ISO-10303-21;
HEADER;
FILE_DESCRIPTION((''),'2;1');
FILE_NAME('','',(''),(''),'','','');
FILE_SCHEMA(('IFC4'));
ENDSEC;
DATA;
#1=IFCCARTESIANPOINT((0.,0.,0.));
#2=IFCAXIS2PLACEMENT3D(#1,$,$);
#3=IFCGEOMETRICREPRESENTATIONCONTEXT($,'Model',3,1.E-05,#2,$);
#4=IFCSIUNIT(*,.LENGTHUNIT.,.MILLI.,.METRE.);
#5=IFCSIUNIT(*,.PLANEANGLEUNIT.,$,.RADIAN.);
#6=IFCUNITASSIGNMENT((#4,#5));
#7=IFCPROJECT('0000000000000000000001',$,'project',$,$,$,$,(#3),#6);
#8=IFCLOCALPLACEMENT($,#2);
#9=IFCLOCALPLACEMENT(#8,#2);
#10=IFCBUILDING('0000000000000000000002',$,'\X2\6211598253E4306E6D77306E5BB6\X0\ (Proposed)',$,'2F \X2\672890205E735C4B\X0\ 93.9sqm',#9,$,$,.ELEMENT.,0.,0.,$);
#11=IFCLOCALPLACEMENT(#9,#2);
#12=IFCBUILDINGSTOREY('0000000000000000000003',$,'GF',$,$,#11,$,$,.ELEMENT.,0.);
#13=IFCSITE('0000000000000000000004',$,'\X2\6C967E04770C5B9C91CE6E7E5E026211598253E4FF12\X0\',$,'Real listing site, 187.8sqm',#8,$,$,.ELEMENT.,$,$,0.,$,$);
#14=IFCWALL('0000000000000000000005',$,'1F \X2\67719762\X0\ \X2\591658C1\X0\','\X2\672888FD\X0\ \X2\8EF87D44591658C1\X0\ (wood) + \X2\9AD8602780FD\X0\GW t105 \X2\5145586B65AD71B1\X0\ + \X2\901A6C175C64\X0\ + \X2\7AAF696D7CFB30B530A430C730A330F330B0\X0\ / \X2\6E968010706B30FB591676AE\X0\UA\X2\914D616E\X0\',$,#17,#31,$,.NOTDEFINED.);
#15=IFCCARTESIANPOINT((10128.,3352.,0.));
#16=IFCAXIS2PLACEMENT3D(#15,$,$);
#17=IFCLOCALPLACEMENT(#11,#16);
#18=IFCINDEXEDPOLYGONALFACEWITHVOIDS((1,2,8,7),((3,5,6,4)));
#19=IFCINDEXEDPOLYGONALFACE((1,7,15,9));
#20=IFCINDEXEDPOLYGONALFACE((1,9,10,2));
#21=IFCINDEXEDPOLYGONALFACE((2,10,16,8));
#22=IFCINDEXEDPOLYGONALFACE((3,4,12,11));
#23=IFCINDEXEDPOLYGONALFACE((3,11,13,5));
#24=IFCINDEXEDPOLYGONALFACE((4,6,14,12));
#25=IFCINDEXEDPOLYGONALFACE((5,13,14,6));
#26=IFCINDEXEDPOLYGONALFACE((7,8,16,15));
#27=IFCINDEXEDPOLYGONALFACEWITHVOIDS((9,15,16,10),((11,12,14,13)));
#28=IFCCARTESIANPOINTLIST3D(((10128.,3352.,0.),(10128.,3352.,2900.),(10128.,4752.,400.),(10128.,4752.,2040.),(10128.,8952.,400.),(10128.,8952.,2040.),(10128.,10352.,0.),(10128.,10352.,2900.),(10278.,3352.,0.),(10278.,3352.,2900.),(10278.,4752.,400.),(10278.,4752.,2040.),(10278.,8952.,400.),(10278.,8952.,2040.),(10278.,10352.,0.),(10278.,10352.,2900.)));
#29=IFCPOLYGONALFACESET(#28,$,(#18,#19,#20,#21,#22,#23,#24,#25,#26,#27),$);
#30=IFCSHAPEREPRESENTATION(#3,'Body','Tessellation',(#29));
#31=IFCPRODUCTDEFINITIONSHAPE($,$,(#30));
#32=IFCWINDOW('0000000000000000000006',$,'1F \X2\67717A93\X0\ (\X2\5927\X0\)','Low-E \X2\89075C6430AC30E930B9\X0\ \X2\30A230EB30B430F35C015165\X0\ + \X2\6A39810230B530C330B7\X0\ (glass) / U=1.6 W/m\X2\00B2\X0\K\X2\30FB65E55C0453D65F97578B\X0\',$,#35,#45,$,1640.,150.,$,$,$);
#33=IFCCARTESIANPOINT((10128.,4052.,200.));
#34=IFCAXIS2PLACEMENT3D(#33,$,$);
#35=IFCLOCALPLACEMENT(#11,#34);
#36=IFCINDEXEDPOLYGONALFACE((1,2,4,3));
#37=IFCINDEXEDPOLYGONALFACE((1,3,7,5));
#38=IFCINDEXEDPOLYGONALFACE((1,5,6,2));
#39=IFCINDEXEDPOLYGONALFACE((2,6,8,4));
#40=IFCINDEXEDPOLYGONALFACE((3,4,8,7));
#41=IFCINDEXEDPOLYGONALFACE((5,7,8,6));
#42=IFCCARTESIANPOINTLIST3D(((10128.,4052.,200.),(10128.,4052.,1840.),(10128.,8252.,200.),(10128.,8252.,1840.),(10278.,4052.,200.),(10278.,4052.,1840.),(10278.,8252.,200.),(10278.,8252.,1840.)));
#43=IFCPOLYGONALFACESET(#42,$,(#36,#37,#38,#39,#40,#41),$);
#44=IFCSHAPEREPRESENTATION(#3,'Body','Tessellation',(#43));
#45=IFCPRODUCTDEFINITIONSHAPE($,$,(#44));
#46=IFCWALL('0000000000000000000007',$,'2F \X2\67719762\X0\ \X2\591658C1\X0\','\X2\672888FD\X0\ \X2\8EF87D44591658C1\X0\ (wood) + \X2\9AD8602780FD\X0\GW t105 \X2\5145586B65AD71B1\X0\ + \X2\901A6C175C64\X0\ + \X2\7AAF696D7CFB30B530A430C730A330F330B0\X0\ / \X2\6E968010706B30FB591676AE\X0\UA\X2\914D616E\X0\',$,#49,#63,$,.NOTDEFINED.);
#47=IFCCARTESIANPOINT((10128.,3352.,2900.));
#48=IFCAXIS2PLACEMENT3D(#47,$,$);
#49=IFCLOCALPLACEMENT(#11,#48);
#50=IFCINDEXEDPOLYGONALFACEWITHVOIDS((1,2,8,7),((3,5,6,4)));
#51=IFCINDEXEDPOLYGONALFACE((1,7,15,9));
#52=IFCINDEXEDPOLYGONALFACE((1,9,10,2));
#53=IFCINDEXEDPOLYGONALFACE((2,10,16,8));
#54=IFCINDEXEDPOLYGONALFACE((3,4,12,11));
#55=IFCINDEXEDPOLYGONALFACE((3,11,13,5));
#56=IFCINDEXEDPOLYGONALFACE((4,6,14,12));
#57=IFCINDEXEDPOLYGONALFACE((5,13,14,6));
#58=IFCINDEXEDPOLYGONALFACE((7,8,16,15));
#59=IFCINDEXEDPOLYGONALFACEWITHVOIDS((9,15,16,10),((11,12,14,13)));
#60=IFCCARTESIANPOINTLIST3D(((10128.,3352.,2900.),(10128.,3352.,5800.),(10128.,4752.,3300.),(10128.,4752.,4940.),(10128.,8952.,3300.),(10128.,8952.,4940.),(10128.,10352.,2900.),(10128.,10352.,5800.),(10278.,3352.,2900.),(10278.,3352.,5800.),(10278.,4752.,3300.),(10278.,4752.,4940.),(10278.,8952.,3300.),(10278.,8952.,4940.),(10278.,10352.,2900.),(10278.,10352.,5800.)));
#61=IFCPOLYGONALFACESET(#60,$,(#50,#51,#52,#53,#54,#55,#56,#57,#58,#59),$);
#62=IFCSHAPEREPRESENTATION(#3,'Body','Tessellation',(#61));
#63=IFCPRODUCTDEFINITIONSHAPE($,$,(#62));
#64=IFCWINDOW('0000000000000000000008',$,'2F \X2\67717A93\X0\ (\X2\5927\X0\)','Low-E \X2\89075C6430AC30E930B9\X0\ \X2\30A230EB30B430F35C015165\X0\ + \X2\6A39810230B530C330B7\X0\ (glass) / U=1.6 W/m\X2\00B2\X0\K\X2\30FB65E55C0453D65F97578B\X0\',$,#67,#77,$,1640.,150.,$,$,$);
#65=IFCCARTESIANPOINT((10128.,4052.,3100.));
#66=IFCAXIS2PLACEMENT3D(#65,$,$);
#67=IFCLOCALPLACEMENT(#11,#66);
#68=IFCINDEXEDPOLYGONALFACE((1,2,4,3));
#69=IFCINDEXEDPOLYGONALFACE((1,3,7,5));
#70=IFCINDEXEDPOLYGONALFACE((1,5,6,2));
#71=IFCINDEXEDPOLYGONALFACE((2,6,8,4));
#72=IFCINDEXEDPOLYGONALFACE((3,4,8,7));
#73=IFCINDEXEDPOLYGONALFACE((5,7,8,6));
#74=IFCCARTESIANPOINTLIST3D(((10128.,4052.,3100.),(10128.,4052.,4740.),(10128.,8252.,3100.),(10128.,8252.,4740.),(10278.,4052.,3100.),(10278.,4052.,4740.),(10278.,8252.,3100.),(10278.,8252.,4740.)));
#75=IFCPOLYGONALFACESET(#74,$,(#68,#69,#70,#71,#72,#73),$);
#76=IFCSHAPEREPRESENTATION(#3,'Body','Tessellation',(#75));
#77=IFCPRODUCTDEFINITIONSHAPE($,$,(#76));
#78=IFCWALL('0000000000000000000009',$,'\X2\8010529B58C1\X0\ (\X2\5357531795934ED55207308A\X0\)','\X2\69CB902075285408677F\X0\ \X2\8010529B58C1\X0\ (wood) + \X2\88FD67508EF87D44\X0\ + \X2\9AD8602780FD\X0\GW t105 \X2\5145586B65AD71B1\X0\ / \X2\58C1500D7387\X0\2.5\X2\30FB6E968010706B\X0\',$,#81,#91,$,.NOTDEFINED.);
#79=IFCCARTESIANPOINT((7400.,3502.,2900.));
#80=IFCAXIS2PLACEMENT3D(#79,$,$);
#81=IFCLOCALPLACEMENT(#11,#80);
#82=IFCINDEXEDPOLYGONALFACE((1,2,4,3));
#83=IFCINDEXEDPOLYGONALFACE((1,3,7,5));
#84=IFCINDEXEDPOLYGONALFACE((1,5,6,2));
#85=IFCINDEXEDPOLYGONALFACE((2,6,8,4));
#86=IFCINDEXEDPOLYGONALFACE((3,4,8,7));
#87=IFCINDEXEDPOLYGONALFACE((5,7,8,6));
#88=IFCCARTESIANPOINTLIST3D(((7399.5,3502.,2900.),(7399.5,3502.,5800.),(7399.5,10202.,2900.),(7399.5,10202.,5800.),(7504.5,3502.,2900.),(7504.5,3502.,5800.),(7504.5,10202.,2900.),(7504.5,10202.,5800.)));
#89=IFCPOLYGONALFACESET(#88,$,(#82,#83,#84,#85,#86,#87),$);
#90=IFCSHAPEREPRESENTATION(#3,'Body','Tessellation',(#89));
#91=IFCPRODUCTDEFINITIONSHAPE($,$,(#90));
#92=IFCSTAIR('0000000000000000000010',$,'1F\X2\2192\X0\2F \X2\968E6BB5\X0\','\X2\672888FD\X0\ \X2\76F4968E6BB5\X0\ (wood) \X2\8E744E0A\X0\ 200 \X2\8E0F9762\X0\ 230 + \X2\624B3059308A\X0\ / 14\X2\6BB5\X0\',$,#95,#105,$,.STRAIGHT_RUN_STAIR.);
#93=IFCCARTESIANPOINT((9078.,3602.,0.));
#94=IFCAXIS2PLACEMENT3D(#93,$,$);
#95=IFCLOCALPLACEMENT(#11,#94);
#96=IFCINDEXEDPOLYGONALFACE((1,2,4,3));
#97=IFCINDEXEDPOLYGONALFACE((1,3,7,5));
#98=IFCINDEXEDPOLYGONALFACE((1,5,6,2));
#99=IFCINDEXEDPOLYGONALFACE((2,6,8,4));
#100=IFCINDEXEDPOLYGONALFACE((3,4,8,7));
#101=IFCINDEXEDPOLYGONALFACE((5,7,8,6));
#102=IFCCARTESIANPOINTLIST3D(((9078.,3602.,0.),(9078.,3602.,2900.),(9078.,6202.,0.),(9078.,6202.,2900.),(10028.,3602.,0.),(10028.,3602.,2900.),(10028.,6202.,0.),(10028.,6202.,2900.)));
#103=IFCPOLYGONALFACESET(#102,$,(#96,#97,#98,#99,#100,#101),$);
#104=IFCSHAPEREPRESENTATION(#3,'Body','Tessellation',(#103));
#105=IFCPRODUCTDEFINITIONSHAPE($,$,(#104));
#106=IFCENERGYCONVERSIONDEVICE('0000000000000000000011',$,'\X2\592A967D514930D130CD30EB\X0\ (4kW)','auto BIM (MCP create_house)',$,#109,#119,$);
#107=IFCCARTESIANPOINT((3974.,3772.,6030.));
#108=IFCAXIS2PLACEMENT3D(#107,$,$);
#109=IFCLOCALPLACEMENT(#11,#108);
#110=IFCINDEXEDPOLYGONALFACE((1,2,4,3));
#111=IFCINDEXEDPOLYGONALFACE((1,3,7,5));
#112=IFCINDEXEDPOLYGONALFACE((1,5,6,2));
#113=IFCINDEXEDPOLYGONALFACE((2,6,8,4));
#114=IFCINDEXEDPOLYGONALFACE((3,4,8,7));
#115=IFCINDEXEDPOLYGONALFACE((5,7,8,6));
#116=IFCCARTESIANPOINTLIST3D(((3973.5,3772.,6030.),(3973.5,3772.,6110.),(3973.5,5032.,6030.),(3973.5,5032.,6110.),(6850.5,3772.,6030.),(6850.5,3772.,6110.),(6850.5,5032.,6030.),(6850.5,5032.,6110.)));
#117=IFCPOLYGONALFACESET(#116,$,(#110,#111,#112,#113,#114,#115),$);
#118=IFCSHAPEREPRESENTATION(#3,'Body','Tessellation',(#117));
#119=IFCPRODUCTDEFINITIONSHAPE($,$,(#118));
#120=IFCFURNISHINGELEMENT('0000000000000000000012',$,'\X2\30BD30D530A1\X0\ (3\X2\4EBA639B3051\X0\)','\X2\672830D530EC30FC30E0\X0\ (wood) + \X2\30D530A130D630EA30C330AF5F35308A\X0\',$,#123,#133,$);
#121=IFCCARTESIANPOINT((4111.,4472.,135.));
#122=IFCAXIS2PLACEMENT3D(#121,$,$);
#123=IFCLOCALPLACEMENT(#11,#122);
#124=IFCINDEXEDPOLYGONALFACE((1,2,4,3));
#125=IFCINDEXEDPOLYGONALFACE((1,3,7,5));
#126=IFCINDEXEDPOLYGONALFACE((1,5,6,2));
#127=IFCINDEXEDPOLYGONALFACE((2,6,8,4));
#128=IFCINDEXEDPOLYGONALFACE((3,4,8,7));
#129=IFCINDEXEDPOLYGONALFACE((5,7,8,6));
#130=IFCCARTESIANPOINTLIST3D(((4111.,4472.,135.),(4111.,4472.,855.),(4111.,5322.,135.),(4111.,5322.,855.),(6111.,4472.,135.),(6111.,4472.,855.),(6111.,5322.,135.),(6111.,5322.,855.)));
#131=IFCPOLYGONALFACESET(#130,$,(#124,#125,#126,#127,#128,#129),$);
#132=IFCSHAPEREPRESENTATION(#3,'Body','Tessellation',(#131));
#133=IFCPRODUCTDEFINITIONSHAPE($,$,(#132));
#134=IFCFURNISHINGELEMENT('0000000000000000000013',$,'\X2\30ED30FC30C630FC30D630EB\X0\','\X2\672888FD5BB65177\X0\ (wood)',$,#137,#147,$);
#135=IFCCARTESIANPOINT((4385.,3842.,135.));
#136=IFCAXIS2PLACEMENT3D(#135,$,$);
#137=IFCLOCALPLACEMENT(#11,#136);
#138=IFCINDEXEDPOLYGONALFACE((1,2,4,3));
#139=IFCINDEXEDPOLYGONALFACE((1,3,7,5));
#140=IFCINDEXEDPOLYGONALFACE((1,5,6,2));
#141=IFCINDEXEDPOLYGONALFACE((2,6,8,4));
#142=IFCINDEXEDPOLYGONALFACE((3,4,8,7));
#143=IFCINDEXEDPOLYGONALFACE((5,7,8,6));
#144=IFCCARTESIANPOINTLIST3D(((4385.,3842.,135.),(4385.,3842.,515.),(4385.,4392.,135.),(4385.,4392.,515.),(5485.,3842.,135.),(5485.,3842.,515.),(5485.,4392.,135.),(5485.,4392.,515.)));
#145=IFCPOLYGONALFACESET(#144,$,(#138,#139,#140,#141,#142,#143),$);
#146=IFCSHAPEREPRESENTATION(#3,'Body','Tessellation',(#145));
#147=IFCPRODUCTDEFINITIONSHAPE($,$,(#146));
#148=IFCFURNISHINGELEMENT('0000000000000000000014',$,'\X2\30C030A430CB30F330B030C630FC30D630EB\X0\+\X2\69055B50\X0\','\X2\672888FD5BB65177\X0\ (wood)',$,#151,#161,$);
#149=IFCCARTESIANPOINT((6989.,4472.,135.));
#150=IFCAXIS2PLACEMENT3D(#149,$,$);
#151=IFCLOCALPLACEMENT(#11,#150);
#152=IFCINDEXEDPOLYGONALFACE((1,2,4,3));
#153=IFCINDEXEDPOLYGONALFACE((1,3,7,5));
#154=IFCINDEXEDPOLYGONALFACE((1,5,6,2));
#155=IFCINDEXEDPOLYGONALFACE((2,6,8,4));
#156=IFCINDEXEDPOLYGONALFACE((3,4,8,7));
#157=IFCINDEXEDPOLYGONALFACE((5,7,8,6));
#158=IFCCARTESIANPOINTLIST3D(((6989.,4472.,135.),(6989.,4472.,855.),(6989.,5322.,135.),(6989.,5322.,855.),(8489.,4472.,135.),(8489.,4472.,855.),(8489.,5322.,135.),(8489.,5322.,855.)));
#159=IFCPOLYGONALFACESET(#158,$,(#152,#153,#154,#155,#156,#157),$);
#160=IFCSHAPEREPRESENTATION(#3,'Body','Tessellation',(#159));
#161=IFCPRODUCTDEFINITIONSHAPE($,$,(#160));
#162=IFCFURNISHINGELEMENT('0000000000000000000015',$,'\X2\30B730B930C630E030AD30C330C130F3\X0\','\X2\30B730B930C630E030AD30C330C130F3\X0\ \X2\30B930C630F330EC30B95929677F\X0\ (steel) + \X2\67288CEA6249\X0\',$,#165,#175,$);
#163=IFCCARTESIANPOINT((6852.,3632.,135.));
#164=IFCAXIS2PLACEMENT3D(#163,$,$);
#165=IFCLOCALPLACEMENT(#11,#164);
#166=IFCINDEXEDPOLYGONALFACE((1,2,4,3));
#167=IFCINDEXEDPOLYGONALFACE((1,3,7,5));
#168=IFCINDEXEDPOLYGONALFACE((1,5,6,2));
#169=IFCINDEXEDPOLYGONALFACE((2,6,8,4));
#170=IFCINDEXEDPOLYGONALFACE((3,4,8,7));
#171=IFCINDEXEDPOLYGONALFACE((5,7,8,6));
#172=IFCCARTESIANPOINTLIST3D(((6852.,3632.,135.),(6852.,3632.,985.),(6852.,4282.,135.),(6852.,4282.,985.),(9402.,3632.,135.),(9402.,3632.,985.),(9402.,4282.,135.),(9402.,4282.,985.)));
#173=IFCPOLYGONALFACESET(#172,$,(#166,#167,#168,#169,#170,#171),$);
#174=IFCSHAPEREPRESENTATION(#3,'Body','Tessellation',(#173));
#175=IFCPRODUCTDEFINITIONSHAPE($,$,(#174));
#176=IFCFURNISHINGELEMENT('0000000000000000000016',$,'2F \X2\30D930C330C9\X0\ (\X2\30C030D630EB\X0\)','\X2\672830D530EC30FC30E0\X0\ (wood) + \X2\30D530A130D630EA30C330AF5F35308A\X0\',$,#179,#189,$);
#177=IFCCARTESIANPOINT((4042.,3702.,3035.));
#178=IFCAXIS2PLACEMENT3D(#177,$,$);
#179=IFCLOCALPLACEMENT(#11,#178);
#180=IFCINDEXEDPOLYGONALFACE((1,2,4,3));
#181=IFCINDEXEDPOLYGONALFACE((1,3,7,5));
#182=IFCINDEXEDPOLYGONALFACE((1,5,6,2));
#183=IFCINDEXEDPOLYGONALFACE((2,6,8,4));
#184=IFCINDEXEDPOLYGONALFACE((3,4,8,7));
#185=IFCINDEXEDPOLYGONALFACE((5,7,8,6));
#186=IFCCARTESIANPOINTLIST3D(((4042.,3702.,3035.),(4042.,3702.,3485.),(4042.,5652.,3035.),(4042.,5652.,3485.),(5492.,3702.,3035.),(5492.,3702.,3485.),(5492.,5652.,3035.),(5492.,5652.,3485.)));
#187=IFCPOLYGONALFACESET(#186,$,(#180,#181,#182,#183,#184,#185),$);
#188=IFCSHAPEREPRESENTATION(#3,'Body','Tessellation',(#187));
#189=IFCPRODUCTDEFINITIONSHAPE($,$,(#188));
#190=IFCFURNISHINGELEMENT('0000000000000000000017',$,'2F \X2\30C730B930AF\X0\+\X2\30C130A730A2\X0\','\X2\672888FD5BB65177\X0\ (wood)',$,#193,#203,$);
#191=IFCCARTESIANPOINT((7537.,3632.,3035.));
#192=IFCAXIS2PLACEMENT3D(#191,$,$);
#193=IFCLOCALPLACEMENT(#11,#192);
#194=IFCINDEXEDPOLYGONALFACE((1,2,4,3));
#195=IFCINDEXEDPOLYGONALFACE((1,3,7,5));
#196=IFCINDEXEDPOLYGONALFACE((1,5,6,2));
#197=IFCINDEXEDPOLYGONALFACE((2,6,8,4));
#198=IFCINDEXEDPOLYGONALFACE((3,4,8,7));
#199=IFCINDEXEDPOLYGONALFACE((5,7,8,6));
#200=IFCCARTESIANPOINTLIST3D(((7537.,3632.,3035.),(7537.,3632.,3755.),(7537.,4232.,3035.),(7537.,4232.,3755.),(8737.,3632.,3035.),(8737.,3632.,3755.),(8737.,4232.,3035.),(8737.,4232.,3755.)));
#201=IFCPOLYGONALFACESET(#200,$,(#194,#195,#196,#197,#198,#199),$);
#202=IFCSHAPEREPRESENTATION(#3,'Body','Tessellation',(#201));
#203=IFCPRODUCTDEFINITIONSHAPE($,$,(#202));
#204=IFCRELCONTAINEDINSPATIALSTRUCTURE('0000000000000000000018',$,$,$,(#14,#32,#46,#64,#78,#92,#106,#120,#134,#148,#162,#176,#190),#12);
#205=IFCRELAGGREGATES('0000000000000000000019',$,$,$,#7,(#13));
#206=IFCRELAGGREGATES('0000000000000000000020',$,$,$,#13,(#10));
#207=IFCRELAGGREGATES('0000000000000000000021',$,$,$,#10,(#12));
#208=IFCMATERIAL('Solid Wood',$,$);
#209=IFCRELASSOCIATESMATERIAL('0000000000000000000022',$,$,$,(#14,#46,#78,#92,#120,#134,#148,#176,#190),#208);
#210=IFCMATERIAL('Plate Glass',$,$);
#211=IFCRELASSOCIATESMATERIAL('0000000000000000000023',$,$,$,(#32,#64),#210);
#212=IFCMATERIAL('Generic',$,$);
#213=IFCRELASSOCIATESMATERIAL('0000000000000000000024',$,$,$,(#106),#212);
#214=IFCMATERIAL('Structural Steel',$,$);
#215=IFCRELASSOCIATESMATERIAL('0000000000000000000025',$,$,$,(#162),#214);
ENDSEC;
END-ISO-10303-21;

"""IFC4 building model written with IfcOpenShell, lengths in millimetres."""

from ifc_helpers import new_model, si_unit, frame, frame_2d, origin, place, context, project, spatial, rectangle, extrude, material, element, fill, save


model = new_model("IFC4")

# Units and contexts
model_context = context("Model", 3, precision=1e-05, world=origin())
ifc_project = project(units=[si_unit("LENGTHUNIT", "METRE", prefix="MILLI"), si_unit("PLANEANGLEUNIT", "RADIAN")], contexts=[model_context])

# Site, building, storey
site_placement = place(None, origin())
site = spatial("IfcSite", under=ifc_project, at=site_placement, Name="沖縄県宜野湾市我如古２", ObjectType="Real listing site, 187.8sqm", CompositionType="ELEMENT", RefElevation=0.0)
building_placement = place(site_placement, origin())
building = spatial("IfcBuilding", under=site, at=building_placement, Name="我如古の海の家 (Proposed)", ObjectType="2F 木造平屋 93.9sqm", CompositionType="ELEMENT", ElevationOfRefHeight=0.0, ElevationOfTerrain=0.0)
storey_placement = place(building_placement, origin())
storey = spatial("IfcBuildingStorey", under=building, at=storey_placement, Name="GF", CompositionType="ELEMENT", Elevation=0.0)

# Wall, opening, window
ifc_material_1 = material(Name="Solid Wood")
wall_1_placement = place(storey_placement, frame((10128.0, 3352.0, 0.0)))
wall_1 = element("IfcWall", 1, at=wall_1_placement, inside=storey, material=ifc_material_1, Name="1F 東面 外壁", Description="木製 軸組外壁 (wood) + 高性能GW t105 充填断熱 + 通気層 + 窯業系サイディング / 準耐火・外皮UA配慮", PredefinedType="NOTDEFINED", context=model_context, shape_type="SweptSolid", body=[
    extrude(rectangle(XDim=150.0, YDim=7000.0, at=frame_2d((75.0, 3500.0))), frame((10128.0, 3352.0, 0.0)), (0.0, 0.0, 1.0), 2900.0),
])
opening_1_placement = place(storey_placement, frame((10128.0, 4052.0, 200.0)))
opening_1 = element("IfcOpeningElement", 2, at=opening_1_placement, cuts=wall_1, PredefinedType="NOTDEFINED", context=model_context, shape_type="SweptSolid", body=[
    extrude(rectangle(XDim=150.0, YDim=4200.0, at=frame_2d((75.0, 2100.0))), frame((10128.0, 4052.0, 200.0)), (0.0, 0.0, 1.0), 1640.0),
])
ifc_material_2 = material(Name="Plate Glass")
window_1_placement = place(storey_placement, frame((10128.0, 4052.0, 200.0)))
window_1 = element("IfcWindow", 3, at=window_1_placement, inside=storey, material=ifc_material_2, Name="1F 東窓 (大)", Description="Low-E 複層ガラス アルゴン封入 + 樹脂サッシ (glass) / U=1.6 W/m²K・日射取得型", OverallHeight=1640.0, OverallWidth=150.0, context=model_context, shape_type="SweptSolid", body=[
    extrude(rectangle(XDim=150.0, YDim=4200.0, at=frame_2d((75.0, 2100.0))), frame((10128.0, 4052.0, 200.0)), (0.0, 0.0, 1.0), 1640.0),
])
fill(opening_1, window_1)

# Wall, opening, window
wall_2_placement = place(storey_placement, frame((10128.0, 3352.0, 2900.0)))
wall_2 = element("IfcWall", 4, at=wall_2_placement, inside=storey, material=ifc_material_1, Name="2F 東面 外壁", Description="木製 軸組外壁 (wood) + 高性能GW t105 充填断熱 + 通気層 + 窯業系サイディング / 準耐火・外皮UA配慮", PredefinedType="NOTDEFINED", context=model_context, shape_type="SweptSolid", body=[
    extrude(rectangle(XDim=150.0, YDim=7000.0, at=frame_2d((75.0, 3500.0))), frame((10128.0, 3352.0, 2900.0)), (0.0, 0.0, 1.0), 2900.0),
])
opening_2_placement = place(storey_placement, frame((10128.0, 4052.0, 3100.0)))
opening_2 = element("IfcOpeningElement", 5, at=opening_2_placement, cuts=wall_2, PredefinedType="NOTDEFINED", context=model_context, shape_type="SweptSolid", body=[
    extrude(rectangle(XDim=150.0, YDim=4200.0, at=frame_2d((75.0, 2100.0))), frame((10128.0, 4052.0, 3100.0)), (0.0, 0.0, 1.0), 1640.0),
])
window_2_placement = place(storey_placement, frame((10128.0, 4052.0, 3100.0)))
window_2 = element("IfcWindow", 6, at=window_2_placement, inside=storey, material=ifc_material_2, Name="2F 東窓 (大)", Description="Low-E 複層ガラス アルゴン封入 + 樹脂サッシ (glass) / U=1.6 W/m²K・日射取得型", OverallHeight=1640.0, OverallWidth=150.0, context=model_context, shape_type="SweptSolid", body=[
    extrude(rectangle(XDim=150.0, YDim=4200.0, at=frame_2d((75.0, 2100.0))), frame((10128.0, 4052.0, 3100.0)), (0.0, 0.0, 1.0), 1640.0),
])
fill(opening_2, window_2)

# Wall
wall_3_placement = place(storey_placement, frame((7400.0, 3502.0, 2900.0)))
element("IfcWall", 7, at=wall_3_placement, inside=storey, material=ifc_material_1, Name="耐力壁 (南北間仕切り)", Description="構造用合板 耐力壁 (wood) + 製材軸組 + 高性能GW t105 充填断熱 / 壁倍率2.5・準耐火", PredefinedType="NOTDEFINED", context=model_context, shape_type="SweptSolid", body=[
    extrude(rectangle(XDim=105.0, YDim=6700.0, at=frame_2d((52.0, 3350.0))), frame((7400.0, 3502.0, 2900.0)), (0.0, 0.0, 1.0), 2900.0),
])

# Stair
stair_placement = place(storey_placement, frame((9078.0, 3602.0, 0.0)))
element("IfcStair", 8, at=stair_placement, inside=storey, material=ifc_material_1, Name="1F→2F 階段", Description="木製 直階段 (wood) 蹴上 200 踏面 230 + 手すり / 14段", PredefinedType="STRAIGHT_RUN_STAIR", context=model_context, shape_type="SweptSolid", body=[
    extrude(rectangle(XDim=950.0, YDim=2600.0, at=frame_2d((475.0, 1300.0))), frame((9078.0, 3602.0, 0.0)), (0.0, 0.0, 1.0), 2900.0),
])

# Energy conversion device
ifc_material_3 = material(Name="Generic")
energy_conversion_device_placement = place(storey_placement, frame((3974.0, 3772.0, 6030.0)))
element("IfcEnergyConversionDevice", 9, at=energy_conversion_device_placement, inside=storey, material=ifc_material_3, Name="太陽光パネル (4kW)", Description="auto BIM (MCP create_house)", context=model_context, shape_type="SweptSolid", body=[
    extrude(rectangle(XDim=2877.0, YDim=1260.0, at=frame_2d((1438.0, 630.0))), frame((3974.0, 3772.0, 6030.0)), (0.0, 0.0, 1.0), 80.0),
])

# Furnishing elements
furnishing_1_placement = place(storey_placement, frame((4111.0, 4472.0, 135.0)))
element("IfcFurnishingElement", 10, at=furnishing_1_placement, inside=storey, material=ifc_material_1, Name="ソファ (3人掛け)", Description="木フレーム (wood) + ファブリック張り", context=model_context, shape_type="SweptSolid", body=[
    extrude(rectangle(XDim=2000.0, YDim=850.0, at=frame_2d((1000.0, 425.0))), frame((4111.0, 4472.0, 135.0)), (0.0, 0.0, 1.0), 720.0),
])
furnishing_2_placement = place(storey_placement, frame((4385.0, 3842.0, 135.0)))
element("IfcFurnishingElement", 11, at=furnishing_2_placement, inside=storey, material=ifc_material_1, Name="ローテーブル", Description="木製家具 (wood)", context=model_context, shape_type="SweptSolid", body=[
    extrude(rectangle(XDim=1100.0, YDim=550.0, at=frame_2d((550.0, 275.0))), frame((4385.0, 3842.0, 135.0)), (0.0, 0.0, 1.0), 380.0),
])
furnishing_3_placement = place(storey_placement, frame((6989.0, 4472.0, 135.0)))
element("IfcFurnishingElement", 12, at=furnishing_3_placement, inside=storey, material=ifc_material_1, Name="ダイニングテーブル+椅子", Description="木製家具 (wood)", context=model_context, shape_type="SweptSolid", body=[
    extrude(rectangle(XDim=1500.0, YDim=850.0, at=frame_2d((750.0, 425.0))), frame((6989.0, 4472.0, 135.0)), (0.0, 0.0, 1.0), 720.0),
])
ifc_material_4 = material(Name="Structural Steel")
furnishing_4_placement = place(storey_placement, frame((6852.0, 3632.0, 135.0)))
element("IfcFurnishingElement", 13, at=furnishing_4_placement, inside=storey, material=ifc_material_4, Name="システムキッチン", Description="システムキッチン ステンレス天板 (steel) + 木質扉", context=model_context, shape_type="SweptSolid", body=[
    extrude(rectangle(XDim=2550.0, YDim=650.0, at=frame_2d((1275.0, 325.0))), frame((6852.0, 3632.0, 135.0)), (0.0, 0.0, 1.0), 850.0),
])
furnishing_5_placement = place(storey_placement, frame((4042.0, 3702.0, 3035.0)))
element("IfcFurnishingElement", 14, at=furnishing_5_placement, inside=storey, material=ifc_material_1, Name="2F ベッド (ダブル)", Description="木フレーム (wood) + ファブリック張り", context=model_context, shape_type="SweptSolid", body=[
    extrude(rectangle(XDim=1450.0, YDim=1950.0, at=frame_2d((725.0, 975.0))), frame((4042.0, 3702.0, 3035.0)), (0.0, 0.0, 1.0), 450.0),
])
furnishing_6_placement = place(storey_placement, frame((7537.0, 3632.0, 3035.0)))
element("IfcFurnishingElement", 15, at=furnishing_6_placement, inside=storey, material=ifc_material_1, Name="2F デスク+チェア", Description="木製家具 (wood)", context=model_context, shape_type="SweptSolid", body=[
    extrude(rectangle(XDim=1200.0, YDim=600.0, at=frame_2d((600.0, 300.0))), frame((7537.0, 3632.0, 3035.0)), (0.0, 0.0, 1.0), 720.0),
])

save(model, "model.ifc")
